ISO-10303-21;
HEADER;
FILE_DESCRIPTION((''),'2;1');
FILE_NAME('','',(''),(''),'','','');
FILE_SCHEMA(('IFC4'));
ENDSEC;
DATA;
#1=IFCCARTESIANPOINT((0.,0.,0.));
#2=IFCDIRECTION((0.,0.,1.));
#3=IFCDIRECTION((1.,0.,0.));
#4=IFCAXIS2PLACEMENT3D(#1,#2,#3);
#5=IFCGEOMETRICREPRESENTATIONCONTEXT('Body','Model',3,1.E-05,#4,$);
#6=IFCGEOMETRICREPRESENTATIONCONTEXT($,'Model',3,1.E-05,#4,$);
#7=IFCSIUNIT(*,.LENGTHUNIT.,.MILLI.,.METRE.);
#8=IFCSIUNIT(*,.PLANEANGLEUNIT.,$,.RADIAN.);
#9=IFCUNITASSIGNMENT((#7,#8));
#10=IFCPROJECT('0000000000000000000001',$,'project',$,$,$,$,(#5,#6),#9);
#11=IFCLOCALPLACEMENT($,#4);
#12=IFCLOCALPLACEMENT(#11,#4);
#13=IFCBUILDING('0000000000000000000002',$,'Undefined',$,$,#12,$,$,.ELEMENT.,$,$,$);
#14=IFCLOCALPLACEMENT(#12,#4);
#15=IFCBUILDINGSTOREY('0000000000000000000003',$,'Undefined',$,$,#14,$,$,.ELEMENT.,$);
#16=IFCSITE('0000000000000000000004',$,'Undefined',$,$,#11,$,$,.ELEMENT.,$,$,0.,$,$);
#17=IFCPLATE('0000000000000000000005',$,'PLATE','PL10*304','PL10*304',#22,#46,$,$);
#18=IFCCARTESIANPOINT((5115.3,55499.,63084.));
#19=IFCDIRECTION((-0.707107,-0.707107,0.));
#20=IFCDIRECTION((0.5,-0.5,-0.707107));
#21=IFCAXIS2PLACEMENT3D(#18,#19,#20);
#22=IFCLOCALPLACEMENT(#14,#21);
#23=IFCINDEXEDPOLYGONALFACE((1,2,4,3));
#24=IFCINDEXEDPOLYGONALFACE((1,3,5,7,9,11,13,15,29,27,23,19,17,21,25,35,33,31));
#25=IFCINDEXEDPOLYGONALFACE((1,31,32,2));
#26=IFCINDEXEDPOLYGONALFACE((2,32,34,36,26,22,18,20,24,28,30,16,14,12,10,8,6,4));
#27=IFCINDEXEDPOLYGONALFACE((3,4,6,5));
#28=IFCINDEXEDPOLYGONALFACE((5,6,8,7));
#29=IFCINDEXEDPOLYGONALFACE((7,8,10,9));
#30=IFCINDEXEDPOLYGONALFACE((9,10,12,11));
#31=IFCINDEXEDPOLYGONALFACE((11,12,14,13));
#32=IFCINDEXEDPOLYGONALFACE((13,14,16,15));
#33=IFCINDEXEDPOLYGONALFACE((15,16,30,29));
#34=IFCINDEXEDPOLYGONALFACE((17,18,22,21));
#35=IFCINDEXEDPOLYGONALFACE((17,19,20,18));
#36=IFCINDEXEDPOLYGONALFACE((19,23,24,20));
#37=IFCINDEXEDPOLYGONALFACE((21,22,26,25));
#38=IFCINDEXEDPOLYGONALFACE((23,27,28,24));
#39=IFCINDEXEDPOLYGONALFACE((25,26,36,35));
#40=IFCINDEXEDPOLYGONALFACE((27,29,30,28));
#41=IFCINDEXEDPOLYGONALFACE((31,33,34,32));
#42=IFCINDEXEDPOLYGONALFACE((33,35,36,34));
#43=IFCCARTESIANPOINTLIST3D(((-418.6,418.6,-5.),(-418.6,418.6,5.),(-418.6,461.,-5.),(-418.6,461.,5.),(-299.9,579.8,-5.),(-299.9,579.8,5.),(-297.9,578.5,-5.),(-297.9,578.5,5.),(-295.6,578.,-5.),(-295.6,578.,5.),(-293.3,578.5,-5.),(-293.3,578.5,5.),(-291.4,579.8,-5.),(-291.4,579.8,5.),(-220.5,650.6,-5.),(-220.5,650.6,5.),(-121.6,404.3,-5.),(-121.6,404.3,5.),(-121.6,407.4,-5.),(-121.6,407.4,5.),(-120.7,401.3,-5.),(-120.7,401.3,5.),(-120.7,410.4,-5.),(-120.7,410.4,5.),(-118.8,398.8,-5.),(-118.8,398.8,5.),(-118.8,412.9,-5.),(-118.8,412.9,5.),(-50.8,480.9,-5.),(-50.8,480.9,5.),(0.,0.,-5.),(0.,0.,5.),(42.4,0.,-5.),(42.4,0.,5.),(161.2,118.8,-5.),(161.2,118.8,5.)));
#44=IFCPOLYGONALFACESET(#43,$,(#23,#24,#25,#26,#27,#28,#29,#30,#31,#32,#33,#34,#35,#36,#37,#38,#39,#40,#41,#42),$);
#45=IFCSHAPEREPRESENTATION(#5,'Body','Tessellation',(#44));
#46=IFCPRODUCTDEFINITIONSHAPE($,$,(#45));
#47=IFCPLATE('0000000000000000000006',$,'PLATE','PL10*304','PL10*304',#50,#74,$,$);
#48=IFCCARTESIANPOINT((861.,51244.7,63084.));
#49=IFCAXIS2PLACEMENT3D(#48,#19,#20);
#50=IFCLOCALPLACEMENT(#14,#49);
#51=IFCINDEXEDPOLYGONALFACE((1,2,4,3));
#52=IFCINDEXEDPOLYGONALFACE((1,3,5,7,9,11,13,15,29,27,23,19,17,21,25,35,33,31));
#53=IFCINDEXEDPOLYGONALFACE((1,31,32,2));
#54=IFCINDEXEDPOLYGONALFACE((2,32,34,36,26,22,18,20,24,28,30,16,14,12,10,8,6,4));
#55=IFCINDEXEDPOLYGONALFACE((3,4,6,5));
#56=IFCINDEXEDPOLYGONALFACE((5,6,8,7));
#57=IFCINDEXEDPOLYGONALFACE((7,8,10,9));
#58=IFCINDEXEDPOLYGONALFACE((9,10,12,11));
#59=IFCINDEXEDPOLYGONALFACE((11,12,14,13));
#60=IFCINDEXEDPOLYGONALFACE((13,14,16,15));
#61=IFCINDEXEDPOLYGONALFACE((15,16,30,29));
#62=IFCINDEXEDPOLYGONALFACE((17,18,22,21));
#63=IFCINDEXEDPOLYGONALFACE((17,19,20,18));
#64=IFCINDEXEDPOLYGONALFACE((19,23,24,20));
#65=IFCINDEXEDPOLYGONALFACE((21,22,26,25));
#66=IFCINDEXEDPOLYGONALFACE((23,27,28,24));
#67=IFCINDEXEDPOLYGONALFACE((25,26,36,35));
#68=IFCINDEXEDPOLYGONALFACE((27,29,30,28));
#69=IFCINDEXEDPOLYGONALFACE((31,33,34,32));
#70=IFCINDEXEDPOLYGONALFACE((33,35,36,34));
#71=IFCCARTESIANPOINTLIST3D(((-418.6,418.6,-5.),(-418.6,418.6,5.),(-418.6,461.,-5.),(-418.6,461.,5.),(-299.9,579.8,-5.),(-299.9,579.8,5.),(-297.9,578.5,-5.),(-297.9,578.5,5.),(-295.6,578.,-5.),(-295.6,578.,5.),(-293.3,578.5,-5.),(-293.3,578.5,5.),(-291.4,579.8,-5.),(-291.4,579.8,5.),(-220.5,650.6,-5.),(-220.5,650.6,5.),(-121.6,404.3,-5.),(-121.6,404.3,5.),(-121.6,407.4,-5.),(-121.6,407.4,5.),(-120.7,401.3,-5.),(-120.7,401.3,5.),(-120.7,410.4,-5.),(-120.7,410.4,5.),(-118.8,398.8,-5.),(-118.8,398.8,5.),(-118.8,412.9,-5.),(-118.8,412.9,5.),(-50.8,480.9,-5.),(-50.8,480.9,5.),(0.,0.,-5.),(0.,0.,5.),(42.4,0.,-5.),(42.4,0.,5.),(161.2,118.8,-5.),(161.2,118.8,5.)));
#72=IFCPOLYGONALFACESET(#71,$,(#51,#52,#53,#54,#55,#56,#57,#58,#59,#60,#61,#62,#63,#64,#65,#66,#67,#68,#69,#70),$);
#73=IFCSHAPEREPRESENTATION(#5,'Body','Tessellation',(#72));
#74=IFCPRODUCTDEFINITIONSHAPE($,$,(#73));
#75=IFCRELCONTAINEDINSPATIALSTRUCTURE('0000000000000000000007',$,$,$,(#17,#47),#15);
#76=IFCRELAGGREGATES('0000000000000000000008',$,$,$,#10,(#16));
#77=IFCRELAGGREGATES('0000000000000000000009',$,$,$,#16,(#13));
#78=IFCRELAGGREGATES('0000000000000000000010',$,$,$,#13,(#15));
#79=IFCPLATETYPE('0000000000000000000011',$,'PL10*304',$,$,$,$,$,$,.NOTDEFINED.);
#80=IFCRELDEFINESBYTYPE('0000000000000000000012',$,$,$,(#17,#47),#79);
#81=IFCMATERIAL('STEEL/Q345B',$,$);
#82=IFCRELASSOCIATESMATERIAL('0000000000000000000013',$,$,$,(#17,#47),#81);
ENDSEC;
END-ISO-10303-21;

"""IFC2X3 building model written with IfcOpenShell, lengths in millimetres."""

from ifc_helpers import new_model, si_unit, frame, origin_with_axes, place, context, project, spatial, polyline, outline, extrude, material, type_object, element, save


model = new_model("IFC2X3")

# Units and contexts
model_context_1 = context("Model", 3, precision=1e-05, world=origin_with_axes(), identifier="Body")
model_context_2 = context("Model", 3, precision=1e-05, world=origin_with_axes())
ifc_project = project(units=[si_unit("LENGTHUNIT", "METRE", prefix="MILLI"), si_unit("PLANEANGLEUNIT", "RADIAN")], contexts=[model_context_1, model_context_2])

# Site, building, storey
site_placement = place(None, origin_with_axes())
site = spatial("IfcSite", under=ifc_project, at=site_placement, Name="Undefined", CompositionType="ELEMENT", RefElevation=0.0)
building_placement = place(site_placement, origin_with_axes())
building = spatial("IfcBuilding", under=site, at=building_placement, Name="Undefined", CompositionType="ELEMENT")
storey_placement = place(building_placement, origin_with_axes())
storey = spatial("IfcBuildingStorey", under=building, at=storey_placement, Name="Undefined", CompositionType="ELEMENT")

# Shared definitions
ifc_material_1 = material(Name="STEEL/Q345B")

# Plates
plate_type_1 = type_object("IfcPlateType", Name="PL10*304", PredefinedType="NOTDEFINED")
plate_1_placement = place(storey_placement, frame((5115.3, 55499.0, 63084.0), z_axis=(-0.707107, -0.707107, 0.0), x_axis=(0.5, -0.5, -0.707107)))
element("IfcPlate", 1, at=plate_1_placement, inside=storey, type_object=plate_type_1, material=ifc_material_1, Name="PLATE", Description="PL10*304", ObjectType="PL10*304", context=model_context_1, shape_type="SweptSolid", body=[
    extrude(outline(polyline([(0.0, 0.0), (42.4, 0.0), (161.2, 118.8), (-118.8, 398.8), (-120.7, 401.3), (-121.6, 404.3), (-121.6, 407.4), (-120.7, 410.4), (-118.8, 412.9), (-50.8, 480.9), (-220.5, 650.6), (-291.4, 579.8), (-293.3, 578.5), (-295.6, 578.0), (-297.9, 578.5), (-299.9, 579.8), (-418.6, 461.0), (-418.6, 418.6), (0.0, 0.0)])), frame((0.0, 0.0, -5.0), z_axis=(0.0, 0.0, 1.0), x_axis=(1.0, 0.0, 0.0)), (0.0, 0.0, 1.0), 10.0),
])
plate_2_placement = place(storey_placement, frame((861.0, 51244.7, 63084.0), z_axis=(-0.707107, -0.707107, 0.0), x_axis=(0.5, -0.5, -0.707107)))
element("IfcPlate", 2, at=plate_2_placement, inside=storey, type_object=plate_type_1, material=ifc_material_1, Name="PLATE", Description="PL10*304", ObjectType="PL10*304", context=model_context_1, shape_type="SweptSolid", body=[
    extrude(outline(polyline([(0.0, 0.0), (42.4, 0.0), (161.2, 118.8), (-118.8, 398.8), (-120.7, 401.3), (-121.6, 404.3), (-121.6, 407.4), (-120.7, 410.4), (-118.8, 412.9), (-50.8, 480.9), (-220.5, 650.6), (-291.4, 579.8), (-293.3, 578.5), (-295.6, 578.0), (-297.9, 578.5), (-299.9, 579.8), (-418.6, 461.0), (-418.6, 418.6), (0.0, 0.0)])), frame((0.0, 0.0, -5.0), z_axis=(0.0, 0.0, 1.0), x_axis=(1.0, 0.0, 0.0)), (0.0, 0.0, 1.0), 10.0),
])

save(model, "model.ifc")
